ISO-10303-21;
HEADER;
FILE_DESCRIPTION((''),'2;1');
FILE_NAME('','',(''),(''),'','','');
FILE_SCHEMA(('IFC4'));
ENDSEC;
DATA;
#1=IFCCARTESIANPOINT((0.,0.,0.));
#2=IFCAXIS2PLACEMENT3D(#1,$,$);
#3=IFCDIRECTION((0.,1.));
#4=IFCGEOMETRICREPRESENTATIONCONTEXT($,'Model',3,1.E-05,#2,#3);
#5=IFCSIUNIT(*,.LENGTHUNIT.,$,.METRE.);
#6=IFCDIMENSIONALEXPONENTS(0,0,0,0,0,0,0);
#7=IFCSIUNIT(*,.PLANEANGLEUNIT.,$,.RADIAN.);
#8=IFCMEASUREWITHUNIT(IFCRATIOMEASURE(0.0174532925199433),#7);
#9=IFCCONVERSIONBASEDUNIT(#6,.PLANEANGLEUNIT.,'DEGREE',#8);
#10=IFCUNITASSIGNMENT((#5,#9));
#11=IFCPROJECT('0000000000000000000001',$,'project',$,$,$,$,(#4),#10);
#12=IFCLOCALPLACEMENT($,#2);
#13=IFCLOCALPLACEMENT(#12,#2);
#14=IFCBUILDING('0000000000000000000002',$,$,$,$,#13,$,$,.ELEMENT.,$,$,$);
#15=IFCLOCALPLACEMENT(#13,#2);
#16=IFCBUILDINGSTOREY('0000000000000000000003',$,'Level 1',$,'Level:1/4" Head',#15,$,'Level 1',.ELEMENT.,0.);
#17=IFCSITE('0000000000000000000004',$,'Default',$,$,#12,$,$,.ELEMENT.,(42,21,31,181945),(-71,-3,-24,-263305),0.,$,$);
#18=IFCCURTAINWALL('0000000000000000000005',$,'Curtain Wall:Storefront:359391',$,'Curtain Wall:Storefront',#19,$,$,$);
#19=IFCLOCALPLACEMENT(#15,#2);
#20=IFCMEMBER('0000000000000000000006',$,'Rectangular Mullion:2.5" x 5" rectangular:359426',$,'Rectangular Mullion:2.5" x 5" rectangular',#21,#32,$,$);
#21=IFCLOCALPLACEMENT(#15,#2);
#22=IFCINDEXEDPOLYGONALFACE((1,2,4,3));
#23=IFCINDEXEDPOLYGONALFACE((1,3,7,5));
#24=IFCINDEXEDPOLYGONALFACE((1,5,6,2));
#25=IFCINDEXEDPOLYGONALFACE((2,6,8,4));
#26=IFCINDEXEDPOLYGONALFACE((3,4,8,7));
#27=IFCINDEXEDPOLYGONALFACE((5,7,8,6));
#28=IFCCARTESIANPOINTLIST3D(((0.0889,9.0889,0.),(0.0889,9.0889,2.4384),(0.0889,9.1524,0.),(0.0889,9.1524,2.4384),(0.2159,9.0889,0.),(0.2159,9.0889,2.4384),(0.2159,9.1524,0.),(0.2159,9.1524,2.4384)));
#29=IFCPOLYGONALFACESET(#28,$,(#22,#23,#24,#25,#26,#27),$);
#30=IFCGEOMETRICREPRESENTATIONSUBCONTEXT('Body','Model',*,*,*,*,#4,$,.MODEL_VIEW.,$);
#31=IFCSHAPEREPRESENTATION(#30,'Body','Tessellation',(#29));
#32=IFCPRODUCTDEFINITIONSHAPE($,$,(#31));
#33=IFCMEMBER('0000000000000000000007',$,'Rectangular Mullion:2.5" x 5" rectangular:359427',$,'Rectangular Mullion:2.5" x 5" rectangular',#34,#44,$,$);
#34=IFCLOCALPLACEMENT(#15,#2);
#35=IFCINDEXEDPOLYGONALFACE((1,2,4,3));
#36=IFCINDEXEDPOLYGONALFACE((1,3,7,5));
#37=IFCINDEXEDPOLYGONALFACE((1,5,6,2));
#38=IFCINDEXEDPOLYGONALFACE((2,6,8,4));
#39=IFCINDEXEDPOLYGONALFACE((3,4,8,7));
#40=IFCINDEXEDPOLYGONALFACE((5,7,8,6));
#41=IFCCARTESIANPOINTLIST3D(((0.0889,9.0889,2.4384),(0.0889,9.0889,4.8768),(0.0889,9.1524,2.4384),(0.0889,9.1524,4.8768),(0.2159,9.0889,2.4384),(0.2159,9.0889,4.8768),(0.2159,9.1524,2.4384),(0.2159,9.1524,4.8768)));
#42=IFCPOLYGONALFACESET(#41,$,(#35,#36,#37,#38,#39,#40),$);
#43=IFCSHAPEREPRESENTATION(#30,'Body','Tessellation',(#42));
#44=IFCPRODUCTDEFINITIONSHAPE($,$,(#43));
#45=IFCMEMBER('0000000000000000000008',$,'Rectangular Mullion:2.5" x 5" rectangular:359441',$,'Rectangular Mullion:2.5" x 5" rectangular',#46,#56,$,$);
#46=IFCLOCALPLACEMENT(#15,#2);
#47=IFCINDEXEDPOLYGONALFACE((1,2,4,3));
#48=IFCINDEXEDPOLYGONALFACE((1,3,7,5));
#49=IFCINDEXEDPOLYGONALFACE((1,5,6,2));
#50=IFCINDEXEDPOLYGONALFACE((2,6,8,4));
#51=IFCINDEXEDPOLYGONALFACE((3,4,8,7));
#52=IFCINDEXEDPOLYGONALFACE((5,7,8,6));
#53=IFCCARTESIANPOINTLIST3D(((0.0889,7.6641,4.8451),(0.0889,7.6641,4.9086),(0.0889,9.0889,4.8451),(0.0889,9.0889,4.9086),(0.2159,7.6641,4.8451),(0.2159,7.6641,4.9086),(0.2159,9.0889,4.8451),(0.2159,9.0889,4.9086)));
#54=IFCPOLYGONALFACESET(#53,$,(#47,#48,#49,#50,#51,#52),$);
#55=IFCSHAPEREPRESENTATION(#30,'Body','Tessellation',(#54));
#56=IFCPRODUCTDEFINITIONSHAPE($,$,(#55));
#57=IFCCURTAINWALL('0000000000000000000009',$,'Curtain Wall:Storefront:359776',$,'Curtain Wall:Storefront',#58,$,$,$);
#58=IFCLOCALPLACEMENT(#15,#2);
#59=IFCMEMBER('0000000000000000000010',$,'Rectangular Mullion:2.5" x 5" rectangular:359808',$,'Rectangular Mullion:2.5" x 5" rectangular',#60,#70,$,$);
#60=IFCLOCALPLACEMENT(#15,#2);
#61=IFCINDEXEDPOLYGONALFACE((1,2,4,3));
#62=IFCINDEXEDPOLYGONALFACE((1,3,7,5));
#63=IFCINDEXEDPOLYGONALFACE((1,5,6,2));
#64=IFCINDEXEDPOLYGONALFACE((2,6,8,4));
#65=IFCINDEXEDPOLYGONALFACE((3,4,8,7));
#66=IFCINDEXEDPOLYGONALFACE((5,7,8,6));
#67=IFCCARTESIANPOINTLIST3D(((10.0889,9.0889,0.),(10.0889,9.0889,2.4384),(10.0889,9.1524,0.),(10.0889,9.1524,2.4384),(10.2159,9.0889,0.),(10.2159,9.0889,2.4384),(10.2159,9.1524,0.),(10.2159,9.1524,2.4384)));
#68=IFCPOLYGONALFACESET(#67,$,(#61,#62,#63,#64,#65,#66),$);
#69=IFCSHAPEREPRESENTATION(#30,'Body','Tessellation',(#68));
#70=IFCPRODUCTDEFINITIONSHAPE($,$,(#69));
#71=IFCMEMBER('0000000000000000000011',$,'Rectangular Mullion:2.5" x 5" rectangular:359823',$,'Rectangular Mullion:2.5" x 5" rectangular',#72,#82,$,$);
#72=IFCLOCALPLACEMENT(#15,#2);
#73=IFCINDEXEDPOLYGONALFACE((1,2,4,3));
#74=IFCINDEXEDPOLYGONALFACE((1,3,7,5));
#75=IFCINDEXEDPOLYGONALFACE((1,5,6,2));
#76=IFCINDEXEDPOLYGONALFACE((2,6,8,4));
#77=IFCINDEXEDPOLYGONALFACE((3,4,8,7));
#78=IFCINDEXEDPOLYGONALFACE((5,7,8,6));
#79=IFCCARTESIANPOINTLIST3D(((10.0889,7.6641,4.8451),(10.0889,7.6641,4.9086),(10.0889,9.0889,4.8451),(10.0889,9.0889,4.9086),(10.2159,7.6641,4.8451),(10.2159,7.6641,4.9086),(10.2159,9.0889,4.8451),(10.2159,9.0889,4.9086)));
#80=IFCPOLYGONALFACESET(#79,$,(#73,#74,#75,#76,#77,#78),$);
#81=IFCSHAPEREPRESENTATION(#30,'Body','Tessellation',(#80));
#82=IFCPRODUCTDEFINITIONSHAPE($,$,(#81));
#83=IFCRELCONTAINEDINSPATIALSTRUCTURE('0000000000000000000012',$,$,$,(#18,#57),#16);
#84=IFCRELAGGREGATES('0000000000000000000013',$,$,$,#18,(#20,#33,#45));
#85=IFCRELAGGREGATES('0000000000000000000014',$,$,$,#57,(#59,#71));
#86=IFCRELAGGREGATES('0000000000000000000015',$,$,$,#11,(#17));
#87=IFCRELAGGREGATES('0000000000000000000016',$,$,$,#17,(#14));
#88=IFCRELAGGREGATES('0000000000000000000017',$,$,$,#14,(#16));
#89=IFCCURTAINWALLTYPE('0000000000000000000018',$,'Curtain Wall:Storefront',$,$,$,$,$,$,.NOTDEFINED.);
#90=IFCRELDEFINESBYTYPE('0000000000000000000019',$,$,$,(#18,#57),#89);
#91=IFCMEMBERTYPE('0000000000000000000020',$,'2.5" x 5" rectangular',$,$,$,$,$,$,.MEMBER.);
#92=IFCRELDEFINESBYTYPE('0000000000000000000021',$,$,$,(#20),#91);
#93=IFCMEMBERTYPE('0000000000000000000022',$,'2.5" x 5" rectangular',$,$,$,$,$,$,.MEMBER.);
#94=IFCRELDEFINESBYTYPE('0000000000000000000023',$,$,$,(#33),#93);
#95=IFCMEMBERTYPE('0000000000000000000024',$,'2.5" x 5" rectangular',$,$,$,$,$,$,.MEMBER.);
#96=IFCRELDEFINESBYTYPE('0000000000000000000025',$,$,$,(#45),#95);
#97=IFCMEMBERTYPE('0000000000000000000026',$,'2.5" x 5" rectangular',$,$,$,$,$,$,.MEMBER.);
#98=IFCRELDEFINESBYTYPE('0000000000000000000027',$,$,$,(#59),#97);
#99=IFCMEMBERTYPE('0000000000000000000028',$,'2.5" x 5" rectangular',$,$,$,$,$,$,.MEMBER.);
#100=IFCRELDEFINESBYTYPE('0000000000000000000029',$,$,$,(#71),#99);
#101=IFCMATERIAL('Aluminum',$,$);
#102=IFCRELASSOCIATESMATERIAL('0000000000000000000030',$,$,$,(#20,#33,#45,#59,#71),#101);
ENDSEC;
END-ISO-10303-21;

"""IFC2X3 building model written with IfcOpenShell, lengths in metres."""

from ifc_helpers import new_model, entity, si_unit, converted_unit, direction, frame, origin, origin_2d_with_axis, place, context, subcontext, project, spatial, rectangle, extrude, source, transform, mapped, material, type_object, type_shapes, element, aggregate, save


model = new_model("IFC2X3")

# Units and contexts
model_context = context("Model", 3, precision=1e-05, world=origin(), true_north=direction((0.0, 1.0)))
body_context = subcontext(model_context, "Body", "Model", "MODEL_VIEW")
ifc_project = project(units=[si_unit("LENGTHUNIT", "METRE"), converted_unit("PLANEANGLEUNIT", "DEGREE", entity("IfcRatioMeasure", 0.0174532925199433), si_unit("PLANEANGLEUNIT", "RADIAN"), dimensions=[0, 0, 0, 0, 0, 0, 0])], contexts=[model_context])

# Site, building, storey
site_placement = place(None, origin())
site = spatial("IfcSite", under=ifc_project, at=site_placement, Name="Default", CompositionType="ELEMENT", RefLatitude=(42, 21, 31, 181945), RefLongitude=(-71, -3, -24, -263305), RefElevation=0.0)
building_placement = place(site_placement, origin())
building = spatial("IfcBuilding", under=site, at=building_placement, CompositionType="ELEMENT")
storey_placement = place(building_placement, origin())
storey = spatial("IfcBuildingStorey", under=building, at=storey_placement, Name="Level 1", ObjectType="Level:1/4\" Head", LongName="Level 1", CompositionType="ELEMENT", Elevation=0.0)

# Curtain walls, members
curtain_wall_type = type_object("IfcCurtainWallType", Name="Curtain Wall:Storefront", PredefinedType="NOTDEFINED")
curtain_wall_1_placement = place(storey_placement, origin())
curtain_wall_1 = element("IfcCurtainWall", 1, at=curtain_wall_1_placement, inside=storey, type_object=curtain_wall_type, Name="Curtain Wall:Storefront:359391", ObjectType="Curtain Wall:Storefront")
ifc_material = material(Name="Aluminum")
member_type_1 = type_object("IfcMemberType", Name="2.5\" x 5\" rectangular", PredefinedType="MEMBER")
shared_shape_1 = source(origin(), body_context, "Body", "SweptSolid", [
    extrude(rectangle(XDim=0.127, YDim=0.0635, at=origin_2d_with_axis()), frame((-0.0318, 0.0, -2.4384), z_axis=(0.0, 0.0, 1.0), x_axis=(0.0, -1.0, 0.0)), (0.0, 0.0, 1.0), 2.4384),
])
type_shapes(member_type_1, [shared_shape_1])
member_1_placement = place(storey_placement, frame((0.1524, 9.1524, 0.0), z_axis=(0.0, 0.0, -1.0), x_axis=(0.0, 1.0, 0.0)))
member_1 = element("IfcMember", 2, at=member_1_placement, type_object=member_type_1, material=ifc_material, Name="Rectangular Mullion:2.5\" x 5\" rectangular:359426", ObjectType="Rectangular Mullion:2.5\" x 5\" rectangular", context=body_context, shape_type="MappedRepresentation", body=[
    mapped(shared_shape_1, transform((0.0, 0.0, 0.0), scale=1.0)),
])
member_type_2 = type_object("IfcMemberType", Name="2.5\" x 5\" rectangular", PredefinedType="MEMBER")
shared_shape_2 = source(origin(), body_context, "Body", "SweptSolid", [
    extrude(rectangle(XDim=0.127, YDim=0.0635, at=origin_2d_with_axis()), frame((-0.0318, 0.0, -2.4384), z_axis=(0.0, 0.0, 1.0), x_axis=(0.0, -1.0, 0.0)), (0.0, 0.0, 1.0), 2.4384),
])
type_shapes(member_type_2, [shared_shape_2])
member_2_placement = place(storey_placement, frame((0.1524, 9.1524, 2.4384), z_axis=(0.0, 0.0, -1.0), x_axis=(0.0, 1.0, 0.0)))
member_2 = element("IfcMember", 3, at=member_2_placement, type_object=member_type_2, material=ifc_material, Name="Rectangular Mullion:2.5\" x 5\" rectangular:359427", ObjectType="Rectangular Mullion:2.5\" x 5\" rectangular", context=body_context, shape_type="MappedRepresentation", body=[
    mapped(shared_shape_2, transform((0.0, 0.0, 0.0), scale=1.0)),
])
member_type_3 = type_object("IfcMemberType", Name="2.5\" x 5\" rectangular", PredefinedType="MEMBER")
shared_shape_3 = source(origin(), body_context, "Body", "SweptSolid", [
    extrude(rectangle(XDim=0.127, YDim=0.0635, at=origin_2d_with_axis()), frame((0.0, 0.0, -1.4248), z_axis=(0.0, 0.0, 1.0), x_axis=(0.0, -1.0, 0.0)), (0.0, 0.0, 1.0), 1.4248),
])
type_shapes(member_type_3, [shared_shape_3])
member_3_placement = place(storey_placement, frame((0.1524, 9.0889, 4.8768), z_axis=(0.0, 1.0, 0.0), x_axis=(0.0, 0.0, 1.0)))
member_3 = element("IfcMember", 4, at=member_3_placement, type_object=member_type_3, material=ifc_material, Name="Rectangular Mullion:2.5\" x 5\" rectangular:359441", ObjectType="Rectangular Mullion:2.5\" x 5\" rectangular", context=body_context, shape_type="MappedRepresentation", body=[
    mapped(shared_shape_3, transform((0.0, 0.0, 0.0), scale=1.0)),
])
aggregate(curtain_wall_1, [member_1, member_2, member_3])
curtain_wall_2_placement = place(storey_placement, origin())
curtain_wall_2 = element("IfcCurtainWall", 5, at=curtain_wall_2_placement, inside=storey, type_object=curtain_wall_type, Name="Curtain Wall:Storefront:359776", ObjectType="Curtain Wall:Storefront")
member_type_4 = type_object("IfcMemberType", Name="2.5\" x 5\" rectangular", PredefinedType="MEMBER")
shared_shape_4 = source(origin(), body_context, "Body", "SweptSolid", [
    extrude(rectangle(XDim=0.127, YDim=0.0635, at=origin_2d_with_axis()), frame((-0.0318, 0.0, -2.4384), z_axis=(0.0, 0.0, 1.0), x_axis=(0.0, -1.0, 0.0)), (0.0, 0.0, 1.0), 2.4384),
])
type_shapes(member_type_4, [shared_shape_4])
member_4_placement = place(storey_placement, frame((10.1524, 9.1524, 0.0), z_axis=(0.0, 0.0, -1.0), x_axis=(0.0, 1.0, 0.0)))
member_4 = element("IfcMember", 6, at=member_4_placement, type_object=member_type_4, material=ifc_material, Name="Rectangular Mullion:2.5\" x 5\" rectangular:359808", ObjectType="Rectangular Mullion:2.5\" x 5\" rectangular", context=body_context, shape_type="MappedRepresentation", body=[
    mapped(shared_shape_4, transform((0.0, 0.0, 0.0), scale=1.0)),
])
member_type_5 = type_object("IfcMemberType", Name="2.5\" x 5\" rectangular", PredefinedType="MEMBER")
shared_shape_5 = source(origin(), body_context, "Body", "SweptSolid", [
    extrude(rectangle(XDim=0.127, YDim=0.0635, at=origin_2d_with_axis()), frame((0.0, 0.0, -1.4248), z_axis=(0.0, 0.0, 1.0), x_axis=(0.0, -1.0, 0.0)), (0.0, 0.0, 1.0), 1.4248),
])
type_shapes(member_type_5, [shared_shape_5])
member_5_placement = place(storey_placement, frame((10.1524, 9.0889, 4.8768), z_axis=(0.0, 1.0, 0.0), x_axis=(0.0, 0.0, 1.0)))
member_5 = element("IfcMember", 7, at=member_5_placement, type_object=member_type_5, material=ifc_material, Name="Rectangular Mullion:2.5\" x 5\" rectangular:359823", ObjectType="Rectangular Mullion:2.5\" x 5\" rectangular", context=body_context, shape_type="MappedRepresentation", body=[
    mapped(shared_shape_5, transform((0.0, 0.0, 0.0), scale=1.0)),
])
aggregate(curtain_wall_2, [member_4, member_5])

save(model, "model.ifc")
